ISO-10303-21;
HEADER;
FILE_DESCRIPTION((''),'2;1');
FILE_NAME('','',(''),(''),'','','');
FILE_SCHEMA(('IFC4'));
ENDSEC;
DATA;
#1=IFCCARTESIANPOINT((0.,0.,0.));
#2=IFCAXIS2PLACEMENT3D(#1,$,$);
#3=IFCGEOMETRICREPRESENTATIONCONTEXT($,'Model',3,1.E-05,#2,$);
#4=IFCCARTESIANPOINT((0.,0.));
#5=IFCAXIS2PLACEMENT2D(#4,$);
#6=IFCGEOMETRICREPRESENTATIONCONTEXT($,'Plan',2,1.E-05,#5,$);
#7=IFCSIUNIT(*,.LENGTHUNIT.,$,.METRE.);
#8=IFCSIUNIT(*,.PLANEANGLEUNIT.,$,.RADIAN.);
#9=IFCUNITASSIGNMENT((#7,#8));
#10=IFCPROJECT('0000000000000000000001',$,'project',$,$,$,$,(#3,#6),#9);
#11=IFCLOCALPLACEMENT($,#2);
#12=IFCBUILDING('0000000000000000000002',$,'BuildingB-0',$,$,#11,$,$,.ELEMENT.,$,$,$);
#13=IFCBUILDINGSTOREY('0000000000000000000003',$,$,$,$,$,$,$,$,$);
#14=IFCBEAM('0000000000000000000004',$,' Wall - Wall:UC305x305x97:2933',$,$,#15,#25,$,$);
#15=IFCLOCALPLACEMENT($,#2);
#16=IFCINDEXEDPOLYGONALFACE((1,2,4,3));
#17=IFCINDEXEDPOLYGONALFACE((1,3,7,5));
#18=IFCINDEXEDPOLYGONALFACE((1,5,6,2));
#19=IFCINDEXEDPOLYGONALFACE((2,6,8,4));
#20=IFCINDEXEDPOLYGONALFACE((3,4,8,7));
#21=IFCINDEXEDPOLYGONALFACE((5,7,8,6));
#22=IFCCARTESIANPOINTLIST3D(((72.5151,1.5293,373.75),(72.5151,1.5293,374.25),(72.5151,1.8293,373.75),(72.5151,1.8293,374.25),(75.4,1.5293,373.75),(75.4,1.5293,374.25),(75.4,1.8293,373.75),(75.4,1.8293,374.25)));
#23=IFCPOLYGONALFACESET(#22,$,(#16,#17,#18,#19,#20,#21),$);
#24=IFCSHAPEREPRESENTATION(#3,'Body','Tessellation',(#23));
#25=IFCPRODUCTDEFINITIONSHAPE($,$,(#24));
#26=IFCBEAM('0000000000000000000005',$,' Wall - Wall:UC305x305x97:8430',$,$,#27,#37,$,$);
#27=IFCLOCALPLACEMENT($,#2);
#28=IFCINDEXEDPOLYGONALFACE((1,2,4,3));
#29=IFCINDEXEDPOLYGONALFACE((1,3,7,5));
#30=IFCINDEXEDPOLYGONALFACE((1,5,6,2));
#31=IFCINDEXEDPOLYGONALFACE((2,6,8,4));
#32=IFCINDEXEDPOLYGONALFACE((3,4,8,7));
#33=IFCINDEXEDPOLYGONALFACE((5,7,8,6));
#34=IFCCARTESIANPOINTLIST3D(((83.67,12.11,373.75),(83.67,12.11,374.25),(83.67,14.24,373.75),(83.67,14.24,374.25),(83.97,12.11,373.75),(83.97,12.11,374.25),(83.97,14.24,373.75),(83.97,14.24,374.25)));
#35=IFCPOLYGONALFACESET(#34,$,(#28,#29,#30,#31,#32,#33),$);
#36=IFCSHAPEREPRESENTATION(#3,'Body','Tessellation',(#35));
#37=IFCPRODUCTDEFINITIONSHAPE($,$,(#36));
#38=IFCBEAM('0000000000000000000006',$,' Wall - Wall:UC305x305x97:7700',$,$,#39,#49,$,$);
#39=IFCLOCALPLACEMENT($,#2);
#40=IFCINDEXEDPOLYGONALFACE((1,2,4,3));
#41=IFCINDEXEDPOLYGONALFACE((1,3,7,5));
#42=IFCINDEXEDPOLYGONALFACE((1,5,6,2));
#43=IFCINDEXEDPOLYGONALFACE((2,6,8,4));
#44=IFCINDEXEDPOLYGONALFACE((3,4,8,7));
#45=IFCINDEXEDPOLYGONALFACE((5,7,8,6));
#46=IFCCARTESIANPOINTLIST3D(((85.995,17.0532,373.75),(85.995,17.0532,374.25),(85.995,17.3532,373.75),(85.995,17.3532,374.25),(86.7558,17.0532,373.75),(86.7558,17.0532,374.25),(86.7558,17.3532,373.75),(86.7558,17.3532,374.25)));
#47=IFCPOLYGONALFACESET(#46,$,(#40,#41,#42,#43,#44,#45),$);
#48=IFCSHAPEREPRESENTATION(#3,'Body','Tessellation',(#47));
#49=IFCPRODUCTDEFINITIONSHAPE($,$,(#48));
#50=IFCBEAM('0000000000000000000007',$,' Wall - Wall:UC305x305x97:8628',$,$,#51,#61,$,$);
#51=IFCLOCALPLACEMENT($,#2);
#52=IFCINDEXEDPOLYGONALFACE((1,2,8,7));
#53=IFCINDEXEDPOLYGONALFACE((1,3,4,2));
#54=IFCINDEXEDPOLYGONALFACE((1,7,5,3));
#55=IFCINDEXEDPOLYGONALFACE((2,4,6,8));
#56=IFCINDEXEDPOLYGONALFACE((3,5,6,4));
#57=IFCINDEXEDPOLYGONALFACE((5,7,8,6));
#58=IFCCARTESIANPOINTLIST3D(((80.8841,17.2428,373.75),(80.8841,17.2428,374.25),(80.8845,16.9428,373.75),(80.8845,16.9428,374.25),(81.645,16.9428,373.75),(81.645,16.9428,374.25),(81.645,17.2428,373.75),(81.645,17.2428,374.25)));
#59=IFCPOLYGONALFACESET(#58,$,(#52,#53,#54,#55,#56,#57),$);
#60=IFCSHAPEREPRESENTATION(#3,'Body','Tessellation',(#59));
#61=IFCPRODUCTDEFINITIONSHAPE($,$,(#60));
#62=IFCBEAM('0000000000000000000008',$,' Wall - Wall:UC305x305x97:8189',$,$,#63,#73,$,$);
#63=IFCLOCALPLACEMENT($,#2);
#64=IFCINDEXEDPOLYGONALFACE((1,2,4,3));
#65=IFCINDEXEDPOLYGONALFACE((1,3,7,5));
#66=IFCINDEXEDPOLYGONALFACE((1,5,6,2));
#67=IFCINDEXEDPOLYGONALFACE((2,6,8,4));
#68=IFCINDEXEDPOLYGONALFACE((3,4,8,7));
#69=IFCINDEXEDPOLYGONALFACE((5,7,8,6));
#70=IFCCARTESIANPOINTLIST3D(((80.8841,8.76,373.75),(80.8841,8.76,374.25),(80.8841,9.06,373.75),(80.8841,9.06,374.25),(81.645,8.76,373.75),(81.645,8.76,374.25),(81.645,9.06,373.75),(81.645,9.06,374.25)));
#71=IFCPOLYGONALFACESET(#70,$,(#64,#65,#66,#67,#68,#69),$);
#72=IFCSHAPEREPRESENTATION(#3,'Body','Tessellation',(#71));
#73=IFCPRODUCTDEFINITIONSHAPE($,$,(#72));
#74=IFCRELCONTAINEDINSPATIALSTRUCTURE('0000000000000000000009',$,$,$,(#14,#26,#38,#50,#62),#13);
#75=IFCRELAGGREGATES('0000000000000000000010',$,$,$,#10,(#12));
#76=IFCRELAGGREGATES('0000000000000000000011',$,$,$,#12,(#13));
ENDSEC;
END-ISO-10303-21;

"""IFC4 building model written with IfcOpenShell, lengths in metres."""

from ifc_helpers import new_model, si_unit, origin, origin_2d, place, context, project, spatial, polyline, outline, extrude, element, save


model = new_model("IFC4")

# Units and contexts
model_context = context("Model", 3, precision=1e-05, world=origin())
plan_context = context("Plan", 2, precision=1e-05, world=origin_2d())
ifc_project = project(units=[si_unit("LENGTHUNIT", "METRE"), si_unit("PLANEANGLEUNIT", "RADIAN")], contexts=[model_context, plan_context])

# Building, storey
building_placement = place(None, origin())
building = spatial("IfcBuilding", under=ifc_project, at=building_placement, Name="BuildingB-0", CompositionType="ELEMENT")
storey = spatial("IfcBuildingStorey", under=building)

# Beams
element("IfcBeam", 1, inside=storey, Name=" Wall - Wall:UC305x305x97:2933", context=model_context, shape_type="SweptSolid", body=[
    extrude(outline(polyline([(75.4, 1.5293, 373.75), (75.4, 1.8293, 373.75), (72.5151, 1.8293, 373.75), (72.5151, 1.5293, 373.75), (75.4, 1.5293, 373.75)])), None, (0.0, 0.0, 1.0), 0.5),
])
element("IfcBeam", 2, inside=storey, Name=" Wall - Wall:UC305x305x97:8430", context=model_context, shape_type="SweptSolid", body=[
    extrude(outline(polyline([(83.97, 12.11, 373.75), (83.67, 12.11, 373.75), (83.67, 14.24, 373.75), (83.97, 14.24, 373.75), (83.97, 12.11, 373.75)])), None, (0.0, 0.0, 1.0), 0.5),
])
element("IfcBeam", 3, inside=storey, Name=" Wall - Wall:UC305x305x97:7700", context=model_context, shape_type="SweptSolid", body=[
    extrude(outline(polyline([(86.7558, 17.0532, 373.75), (86.7558, 17.3532, 373.75), (85.995, 17.3532, 373.75), (85.995, 17.0532, 373.75), (86.7558, 17.0532, 373.75)])), None, (0.0, 0.0, 1.0), 0.5),
])
element("IfcBeam", 4, inside=storey, Name=" Wall - Wall:UC305x305x97:8628", context=model_context, shape_type="SweptSolid", body=[
    extrude(outline(polyline([(81.645, 16.9428, 373.75), (80.8845, 16.9428, 373.75), (80.8841, 17.2428, 373.75), (81.645, 17.2428, 373.75), (81.645, 16.9428, 373.75)])), None, (0.0, 0.0, 1.0), 0.5),
])
element("IfcBeam", 5, inside=storey, Name=" Wall - Wall:UC305x305x97:8189", context=model_context, shape_type="SweptSolid", body=[
    extrude(outline(polyline([(81.645, 8.76, 373.75), (80.8841, 8.76, 373.75), (80.8841, 9.06, 373.75), (81.645, 9.06, 373.75), (81.645, 8.76, 373.75)])), None, (0.0, 0.0, 1.0), 0.5),
])

save(model, "model.ifc")
